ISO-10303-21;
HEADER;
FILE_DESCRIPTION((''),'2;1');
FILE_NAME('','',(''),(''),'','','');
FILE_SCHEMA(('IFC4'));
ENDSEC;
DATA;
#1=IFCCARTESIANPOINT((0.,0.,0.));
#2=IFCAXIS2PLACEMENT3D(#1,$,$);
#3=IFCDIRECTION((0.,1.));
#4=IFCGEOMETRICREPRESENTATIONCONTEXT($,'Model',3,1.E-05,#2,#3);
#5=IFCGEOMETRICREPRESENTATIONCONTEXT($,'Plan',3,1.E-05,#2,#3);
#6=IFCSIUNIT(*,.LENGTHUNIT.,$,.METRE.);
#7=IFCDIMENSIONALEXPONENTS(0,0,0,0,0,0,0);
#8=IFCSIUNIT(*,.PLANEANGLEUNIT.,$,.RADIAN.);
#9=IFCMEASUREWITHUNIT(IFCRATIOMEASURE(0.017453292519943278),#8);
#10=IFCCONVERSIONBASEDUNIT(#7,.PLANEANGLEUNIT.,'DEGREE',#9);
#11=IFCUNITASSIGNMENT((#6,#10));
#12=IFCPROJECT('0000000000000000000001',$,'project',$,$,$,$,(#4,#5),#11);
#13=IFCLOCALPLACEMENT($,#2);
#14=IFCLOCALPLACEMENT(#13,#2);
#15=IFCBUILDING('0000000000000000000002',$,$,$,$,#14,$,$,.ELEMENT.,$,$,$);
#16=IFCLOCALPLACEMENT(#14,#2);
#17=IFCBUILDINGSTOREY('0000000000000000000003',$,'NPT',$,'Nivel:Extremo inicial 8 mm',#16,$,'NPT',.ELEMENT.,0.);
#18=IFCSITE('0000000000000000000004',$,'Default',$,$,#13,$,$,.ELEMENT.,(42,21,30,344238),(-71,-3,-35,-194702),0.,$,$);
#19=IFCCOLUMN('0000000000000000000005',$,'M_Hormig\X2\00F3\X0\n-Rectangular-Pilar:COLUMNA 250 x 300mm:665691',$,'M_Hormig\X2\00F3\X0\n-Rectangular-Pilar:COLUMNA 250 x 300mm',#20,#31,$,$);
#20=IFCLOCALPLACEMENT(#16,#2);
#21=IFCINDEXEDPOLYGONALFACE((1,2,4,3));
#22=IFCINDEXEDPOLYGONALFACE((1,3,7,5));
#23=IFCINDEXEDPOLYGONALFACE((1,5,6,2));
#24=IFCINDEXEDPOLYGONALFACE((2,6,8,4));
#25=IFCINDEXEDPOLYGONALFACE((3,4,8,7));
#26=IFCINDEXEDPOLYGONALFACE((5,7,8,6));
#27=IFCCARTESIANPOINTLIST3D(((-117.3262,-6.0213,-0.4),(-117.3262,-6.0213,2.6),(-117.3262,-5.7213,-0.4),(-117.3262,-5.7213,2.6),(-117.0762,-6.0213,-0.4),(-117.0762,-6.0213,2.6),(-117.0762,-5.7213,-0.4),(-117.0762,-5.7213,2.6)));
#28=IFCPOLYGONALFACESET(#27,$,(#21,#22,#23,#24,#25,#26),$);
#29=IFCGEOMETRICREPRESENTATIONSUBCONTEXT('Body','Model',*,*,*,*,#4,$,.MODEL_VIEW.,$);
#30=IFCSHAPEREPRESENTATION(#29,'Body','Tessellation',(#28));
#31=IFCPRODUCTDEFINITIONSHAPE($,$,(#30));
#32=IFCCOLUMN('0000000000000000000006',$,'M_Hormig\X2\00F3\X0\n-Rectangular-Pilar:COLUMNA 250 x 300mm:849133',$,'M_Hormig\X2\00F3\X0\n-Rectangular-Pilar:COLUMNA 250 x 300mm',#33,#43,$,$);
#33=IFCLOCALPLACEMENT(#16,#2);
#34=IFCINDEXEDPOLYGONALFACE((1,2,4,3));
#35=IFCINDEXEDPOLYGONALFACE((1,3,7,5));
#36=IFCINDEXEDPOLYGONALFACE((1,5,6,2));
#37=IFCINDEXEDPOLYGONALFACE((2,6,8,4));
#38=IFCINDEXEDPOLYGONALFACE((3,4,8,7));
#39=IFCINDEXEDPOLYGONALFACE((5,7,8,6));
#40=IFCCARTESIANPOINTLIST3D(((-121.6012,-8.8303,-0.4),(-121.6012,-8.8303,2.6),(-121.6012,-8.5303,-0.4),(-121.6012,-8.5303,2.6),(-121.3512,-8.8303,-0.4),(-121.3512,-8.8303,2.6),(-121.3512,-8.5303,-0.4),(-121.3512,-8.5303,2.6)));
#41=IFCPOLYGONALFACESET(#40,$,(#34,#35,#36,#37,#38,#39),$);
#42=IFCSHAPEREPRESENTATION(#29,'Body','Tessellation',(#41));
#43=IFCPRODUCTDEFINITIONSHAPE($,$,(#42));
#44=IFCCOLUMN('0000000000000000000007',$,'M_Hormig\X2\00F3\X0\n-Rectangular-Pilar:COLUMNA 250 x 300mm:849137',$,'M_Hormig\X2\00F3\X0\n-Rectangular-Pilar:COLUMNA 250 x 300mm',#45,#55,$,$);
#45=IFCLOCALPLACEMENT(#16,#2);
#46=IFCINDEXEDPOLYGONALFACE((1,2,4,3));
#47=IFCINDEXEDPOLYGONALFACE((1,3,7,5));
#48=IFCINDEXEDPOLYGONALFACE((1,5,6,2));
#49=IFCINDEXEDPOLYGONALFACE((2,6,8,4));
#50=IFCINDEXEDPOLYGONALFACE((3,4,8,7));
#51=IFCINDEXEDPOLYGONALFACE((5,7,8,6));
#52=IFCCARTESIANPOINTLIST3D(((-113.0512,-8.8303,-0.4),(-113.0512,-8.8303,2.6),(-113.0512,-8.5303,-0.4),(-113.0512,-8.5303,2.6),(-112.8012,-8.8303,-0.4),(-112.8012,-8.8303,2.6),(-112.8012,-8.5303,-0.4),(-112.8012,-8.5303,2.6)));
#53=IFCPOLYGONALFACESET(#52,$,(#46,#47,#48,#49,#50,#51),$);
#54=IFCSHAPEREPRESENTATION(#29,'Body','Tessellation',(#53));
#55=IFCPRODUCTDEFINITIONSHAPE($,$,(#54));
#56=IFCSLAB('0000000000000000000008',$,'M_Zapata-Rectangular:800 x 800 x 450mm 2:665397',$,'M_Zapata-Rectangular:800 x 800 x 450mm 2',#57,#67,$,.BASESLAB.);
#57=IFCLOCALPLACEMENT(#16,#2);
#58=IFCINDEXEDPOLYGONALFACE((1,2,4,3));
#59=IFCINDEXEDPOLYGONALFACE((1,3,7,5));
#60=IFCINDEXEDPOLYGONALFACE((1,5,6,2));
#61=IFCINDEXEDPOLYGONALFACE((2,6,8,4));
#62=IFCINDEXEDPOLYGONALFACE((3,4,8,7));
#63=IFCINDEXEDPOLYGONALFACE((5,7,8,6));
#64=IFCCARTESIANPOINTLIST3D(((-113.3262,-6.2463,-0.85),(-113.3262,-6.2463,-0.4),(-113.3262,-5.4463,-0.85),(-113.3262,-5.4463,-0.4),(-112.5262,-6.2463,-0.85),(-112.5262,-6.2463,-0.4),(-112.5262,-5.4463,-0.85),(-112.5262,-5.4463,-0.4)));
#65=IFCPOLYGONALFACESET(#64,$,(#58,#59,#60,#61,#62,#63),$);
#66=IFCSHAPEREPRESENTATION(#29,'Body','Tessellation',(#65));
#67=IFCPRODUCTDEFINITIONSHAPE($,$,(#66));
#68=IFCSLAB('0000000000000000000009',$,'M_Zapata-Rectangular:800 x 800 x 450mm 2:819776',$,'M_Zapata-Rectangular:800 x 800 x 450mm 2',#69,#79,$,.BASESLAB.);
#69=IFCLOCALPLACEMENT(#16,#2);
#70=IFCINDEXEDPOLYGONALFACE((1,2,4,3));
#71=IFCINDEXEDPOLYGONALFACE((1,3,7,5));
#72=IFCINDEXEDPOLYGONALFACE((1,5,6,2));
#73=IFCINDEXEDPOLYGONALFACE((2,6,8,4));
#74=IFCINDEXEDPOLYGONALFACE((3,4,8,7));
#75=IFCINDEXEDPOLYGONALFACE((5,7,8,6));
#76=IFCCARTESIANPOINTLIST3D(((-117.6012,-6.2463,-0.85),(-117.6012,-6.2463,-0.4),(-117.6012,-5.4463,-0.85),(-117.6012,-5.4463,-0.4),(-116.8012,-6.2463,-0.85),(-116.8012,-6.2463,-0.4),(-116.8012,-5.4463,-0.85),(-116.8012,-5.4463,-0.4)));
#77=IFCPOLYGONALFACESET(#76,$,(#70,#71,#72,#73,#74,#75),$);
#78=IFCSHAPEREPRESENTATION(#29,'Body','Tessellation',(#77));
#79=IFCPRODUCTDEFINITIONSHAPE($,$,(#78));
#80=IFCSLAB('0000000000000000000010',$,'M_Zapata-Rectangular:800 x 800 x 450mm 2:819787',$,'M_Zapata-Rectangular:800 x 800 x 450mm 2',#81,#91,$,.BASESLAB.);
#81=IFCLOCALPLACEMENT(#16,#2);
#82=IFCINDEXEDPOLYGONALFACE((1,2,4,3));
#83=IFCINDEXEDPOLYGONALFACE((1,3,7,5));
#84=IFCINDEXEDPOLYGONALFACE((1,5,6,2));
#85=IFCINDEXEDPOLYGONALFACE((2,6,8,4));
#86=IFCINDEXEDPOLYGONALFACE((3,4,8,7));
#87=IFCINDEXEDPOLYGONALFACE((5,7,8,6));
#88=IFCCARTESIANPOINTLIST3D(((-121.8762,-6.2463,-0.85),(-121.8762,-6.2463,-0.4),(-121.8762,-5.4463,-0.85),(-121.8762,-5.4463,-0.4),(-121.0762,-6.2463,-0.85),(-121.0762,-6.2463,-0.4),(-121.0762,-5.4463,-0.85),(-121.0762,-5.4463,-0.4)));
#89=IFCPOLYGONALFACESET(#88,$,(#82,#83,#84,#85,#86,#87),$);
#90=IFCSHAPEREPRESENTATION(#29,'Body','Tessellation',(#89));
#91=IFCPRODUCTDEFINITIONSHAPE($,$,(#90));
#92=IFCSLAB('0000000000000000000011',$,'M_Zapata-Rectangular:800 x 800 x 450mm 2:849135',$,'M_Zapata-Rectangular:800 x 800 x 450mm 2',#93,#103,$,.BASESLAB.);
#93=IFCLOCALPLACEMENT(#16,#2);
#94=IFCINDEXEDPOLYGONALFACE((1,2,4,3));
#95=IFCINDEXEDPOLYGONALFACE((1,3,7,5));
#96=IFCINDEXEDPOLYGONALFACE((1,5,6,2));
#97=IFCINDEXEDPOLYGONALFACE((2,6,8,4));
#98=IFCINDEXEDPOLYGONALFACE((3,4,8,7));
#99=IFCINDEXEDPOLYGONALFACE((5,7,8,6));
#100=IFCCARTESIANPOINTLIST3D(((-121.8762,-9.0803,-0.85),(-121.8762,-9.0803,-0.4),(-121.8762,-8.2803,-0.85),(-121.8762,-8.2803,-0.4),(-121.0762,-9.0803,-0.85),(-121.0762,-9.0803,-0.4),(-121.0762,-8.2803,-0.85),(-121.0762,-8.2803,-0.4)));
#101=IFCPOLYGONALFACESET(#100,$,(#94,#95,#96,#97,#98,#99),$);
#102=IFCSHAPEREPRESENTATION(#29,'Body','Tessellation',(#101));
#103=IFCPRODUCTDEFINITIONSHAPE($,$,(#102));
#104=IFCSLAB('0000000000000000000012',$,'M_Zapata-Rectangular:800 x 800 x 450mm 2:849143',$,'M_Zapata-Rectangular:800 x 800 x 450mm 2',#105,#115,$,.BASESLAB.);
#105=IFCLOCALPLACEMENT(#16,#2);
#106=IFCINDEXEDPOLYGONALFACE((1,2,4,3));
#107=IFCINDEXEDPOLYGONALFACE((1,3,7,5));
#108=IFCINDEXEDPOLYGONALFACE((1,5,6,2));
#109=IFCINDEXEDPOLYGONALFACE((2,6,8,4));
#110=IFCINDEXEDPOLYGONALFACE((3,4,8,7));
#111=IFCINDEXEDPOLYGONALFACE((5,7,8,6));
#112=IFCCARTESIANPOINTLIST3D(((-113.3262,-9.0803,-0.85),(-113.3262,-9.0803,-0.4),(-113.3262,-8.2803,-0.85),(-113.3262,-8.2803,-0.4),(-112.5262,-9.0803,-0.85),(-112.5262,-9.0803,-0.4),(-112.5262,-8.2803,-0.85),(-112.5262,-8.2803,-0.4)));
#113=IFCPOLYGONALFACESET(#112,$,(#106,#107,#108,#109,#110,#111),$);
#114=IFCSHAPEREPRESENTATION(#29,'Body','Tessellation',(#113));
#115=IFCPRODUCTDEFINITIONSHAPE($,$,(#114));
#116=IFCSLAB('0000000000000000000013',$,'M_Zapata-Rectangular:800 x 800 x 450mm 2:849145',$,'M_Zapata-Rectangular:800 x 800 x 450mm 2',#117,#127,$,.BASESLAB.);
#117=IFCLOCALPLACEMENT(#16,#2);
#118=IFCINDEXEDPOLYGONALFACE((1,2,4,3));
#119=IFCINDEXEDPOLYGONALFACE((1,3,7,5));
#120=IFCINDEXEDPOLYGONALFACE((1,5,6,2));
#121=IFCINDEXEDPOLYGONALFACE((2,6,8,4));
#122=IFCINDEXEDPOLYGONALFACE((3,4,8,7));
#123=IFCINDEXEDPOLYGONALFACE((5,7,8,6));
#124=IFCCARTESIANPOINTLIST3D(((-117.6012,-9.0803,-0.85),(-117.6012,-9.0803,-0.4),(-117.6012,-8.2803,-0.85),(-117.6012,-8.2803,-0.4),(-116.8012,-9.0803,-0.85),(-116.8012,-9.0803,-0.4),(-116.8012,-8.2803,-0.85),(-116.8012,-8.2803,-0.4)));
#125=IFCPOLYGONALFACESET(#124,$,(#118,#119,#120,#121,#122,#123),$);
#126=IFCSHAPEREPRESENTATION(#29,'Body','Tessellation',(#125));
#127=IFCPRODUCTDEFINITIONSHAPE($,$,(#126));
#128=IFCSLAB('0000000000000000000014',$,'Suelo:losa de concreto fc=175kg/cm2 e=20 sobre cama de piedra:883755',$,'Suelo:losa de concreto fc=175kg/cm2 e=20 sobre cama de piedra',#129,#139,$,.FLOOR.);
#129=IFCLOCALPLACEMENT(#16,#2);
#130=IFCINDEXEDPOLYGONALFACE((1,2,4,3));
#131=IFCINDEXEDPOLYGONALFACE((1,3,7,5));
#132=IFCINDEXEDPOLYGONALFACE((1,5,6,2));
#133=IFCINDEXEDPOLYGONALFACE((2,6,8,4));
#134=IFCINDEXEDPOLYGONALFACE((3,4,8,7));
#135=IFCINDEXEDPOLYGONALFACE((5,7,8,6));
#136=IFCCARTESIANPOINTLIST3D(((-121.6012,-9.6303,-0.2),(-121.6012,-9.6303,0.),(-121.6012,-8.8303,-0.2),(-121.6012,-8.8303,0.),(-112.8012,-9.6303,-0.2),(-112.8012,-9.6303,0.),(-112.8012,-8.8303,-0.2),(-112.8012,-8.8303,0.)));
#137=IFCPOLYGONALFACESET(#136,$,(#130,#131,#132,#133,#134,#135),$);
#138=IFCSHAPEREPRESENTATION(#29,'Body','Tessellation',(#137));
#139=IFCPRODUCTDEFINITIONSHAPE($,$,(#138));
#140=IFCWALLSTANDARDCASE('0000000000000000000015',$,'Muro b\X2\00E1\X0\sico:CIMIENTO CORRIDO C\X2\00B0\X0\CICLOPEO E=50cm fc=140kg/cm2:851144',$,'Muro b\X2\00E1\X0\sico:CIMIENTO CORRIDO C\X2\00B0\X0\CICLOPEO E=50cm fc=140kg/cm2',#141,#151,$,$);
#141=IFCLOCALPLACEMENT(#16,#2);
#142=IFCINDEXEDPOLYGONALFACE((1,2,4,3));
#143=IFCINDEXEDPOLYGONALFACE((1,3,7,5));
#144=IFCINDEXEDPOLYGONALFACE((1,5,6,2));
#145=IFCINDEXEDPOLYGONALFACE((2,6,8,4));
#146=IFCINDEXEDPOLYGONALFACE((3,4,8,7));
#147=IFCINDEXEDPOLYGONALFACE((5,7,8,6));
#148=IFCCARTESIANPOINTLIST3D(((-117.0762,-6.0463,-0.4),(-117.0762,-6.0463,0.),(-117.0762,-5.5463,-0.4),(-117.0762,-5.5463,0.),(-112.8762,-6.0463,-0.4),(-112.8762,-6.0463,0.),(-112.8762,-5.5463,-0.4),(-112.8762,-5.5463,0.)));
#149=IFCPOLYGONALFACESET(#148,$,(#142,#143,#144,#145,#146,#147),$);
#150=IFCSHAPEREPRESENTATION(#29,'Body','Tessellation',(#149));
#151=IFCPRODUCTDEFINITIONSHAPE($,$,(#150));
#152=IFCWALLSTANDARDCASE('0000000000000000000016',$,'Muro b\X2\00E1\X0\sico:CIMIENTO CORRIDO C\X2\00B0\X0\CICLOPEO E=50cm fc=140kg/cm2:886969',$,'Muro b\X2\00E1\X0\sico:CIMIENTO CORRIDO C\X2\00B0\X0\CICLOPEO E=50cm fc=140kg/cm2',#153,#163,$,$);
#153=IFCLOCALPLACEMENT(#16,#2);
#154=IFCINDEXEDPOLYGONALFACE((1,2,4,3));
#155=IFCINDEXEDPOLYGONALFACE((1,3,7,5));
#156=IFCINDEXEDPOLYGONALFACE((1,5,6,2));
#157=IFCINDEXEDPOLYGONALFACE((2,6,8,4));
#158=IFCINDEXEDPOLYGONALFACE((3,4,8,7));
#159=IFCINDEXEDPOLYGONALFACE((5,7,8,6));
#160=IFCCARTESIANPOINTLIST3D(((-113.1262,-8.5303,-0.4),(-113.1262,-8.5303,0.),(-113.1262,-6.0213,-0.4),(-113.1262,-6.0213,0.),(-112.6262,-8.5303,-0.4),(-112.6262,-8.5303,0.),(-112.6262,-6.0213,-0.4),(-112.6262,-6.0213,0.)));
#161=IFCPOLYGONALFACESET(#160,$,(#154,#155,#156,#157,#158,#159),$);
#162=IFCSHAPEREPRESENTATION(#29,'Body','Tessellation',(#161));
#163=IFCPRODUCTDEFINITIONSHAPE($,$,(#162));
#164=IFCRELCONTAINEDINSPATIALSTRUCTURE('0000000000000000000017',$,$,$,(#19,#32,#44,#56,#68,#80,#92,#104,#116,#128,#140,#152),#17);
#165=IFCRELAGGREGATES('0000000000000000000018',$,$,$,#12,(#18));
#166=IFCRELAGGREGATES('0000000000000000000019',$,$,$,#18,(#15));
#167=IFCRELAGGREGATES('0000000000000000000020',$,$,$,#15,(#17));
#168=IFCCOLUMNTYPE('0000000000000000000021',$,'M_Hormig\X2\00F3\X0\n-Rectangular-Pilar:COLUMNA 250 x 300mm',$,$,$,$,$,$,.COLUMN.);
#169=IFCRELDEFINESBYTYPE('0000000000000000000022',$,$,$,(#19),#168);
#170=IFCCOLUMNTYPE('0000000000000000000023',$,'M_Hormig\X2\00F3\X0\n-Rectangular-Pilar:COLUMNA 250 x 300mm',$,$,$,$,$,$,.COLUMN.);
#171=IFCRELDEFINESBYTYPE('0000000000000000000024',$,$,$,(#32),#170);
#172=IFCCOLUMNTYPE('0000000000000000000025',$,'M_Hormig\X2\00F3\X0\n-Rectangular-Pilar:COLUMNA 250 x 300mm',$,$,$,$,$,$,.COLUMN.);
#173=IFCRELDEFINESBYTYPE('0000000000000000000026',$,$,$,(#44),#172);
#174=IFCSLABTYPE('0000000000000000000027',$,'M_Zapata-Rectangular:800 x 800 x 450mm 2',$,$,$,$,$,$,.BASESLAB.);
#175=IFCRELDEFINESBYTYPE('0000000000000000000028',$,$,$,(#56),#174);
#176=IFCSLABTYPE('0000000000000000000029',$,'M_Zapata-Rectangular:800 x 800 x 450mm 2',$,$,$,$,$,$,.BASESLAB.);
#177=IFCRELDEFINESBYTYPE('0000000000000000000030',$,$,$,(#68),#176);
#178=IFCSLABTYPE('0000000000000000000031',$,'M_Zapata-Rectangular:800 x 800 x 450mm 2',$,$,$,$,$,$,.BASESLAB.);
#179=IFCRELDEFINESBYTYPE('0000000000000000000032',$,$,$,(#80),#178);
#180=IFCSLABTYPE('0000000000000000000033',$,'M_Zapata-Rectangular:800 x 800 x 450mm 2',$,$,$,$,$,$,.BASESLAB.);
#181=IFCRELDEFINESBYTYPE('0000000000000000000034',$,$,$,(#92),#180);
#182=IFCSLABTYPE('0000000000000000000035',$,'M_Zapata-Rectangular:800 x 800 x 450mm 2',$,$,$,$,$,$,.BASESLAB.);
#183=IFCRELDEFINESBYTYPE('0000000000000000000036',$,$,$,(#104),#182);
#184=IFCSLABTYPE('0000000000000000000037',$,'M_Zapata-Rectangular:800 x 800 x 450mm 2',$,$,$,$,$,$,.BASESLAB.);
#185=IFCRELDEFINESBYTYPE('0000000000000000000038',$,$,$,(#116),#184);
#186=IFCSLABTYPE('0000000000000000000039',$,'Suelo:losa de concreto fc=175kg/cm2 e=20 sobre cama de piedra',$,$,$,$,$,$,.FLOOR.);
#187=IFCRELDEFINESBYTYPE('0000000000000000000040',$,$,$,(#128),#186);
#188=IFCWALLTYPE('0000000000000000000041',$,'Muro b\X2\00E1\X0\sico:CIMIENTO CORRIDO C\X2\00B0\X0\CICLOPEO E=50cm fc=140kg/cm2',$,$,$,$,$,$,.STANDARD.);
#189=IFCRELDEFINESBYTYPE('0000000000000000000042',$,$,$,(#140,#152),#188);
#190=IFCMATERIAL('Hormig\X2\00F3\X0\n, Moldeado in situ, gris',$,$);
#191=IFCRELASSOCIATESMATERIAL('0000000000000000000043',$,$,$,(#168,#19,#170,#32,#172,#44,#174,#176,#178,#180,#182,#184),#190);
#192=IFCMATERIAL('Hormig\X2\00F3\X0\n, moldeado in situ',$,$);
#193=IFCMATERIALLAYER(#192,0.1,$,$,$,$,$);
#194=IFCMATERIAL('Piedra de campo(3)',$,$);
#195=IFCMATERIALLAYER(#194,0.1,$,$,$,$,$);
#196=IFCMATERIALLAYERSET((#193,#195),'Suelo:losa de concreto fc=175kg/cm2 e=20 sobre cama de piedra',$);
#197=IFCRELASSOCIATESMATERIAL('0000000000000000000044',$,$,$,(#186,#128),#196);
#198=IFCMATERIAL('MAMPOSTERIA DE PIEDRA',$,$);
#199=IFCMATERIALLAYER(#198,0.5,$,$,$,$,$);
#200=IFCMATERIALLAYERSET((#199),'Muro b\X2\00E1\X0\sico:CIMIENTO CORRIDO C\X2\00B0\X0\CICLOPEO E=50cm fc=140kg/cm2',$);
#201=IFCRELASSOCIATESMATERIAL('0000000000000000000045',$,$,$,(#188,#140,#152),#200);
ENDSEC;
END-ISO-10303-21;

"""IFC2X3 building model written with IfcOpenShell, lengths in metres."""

from ifc_helpers import new_model, entity, si_unit, converted_unit, direction, frame, frame_2d, origin, origin_2d_with_axis, place, context, subcontext, project, spatial, rectangle, extrude, source, transform, mapped, material, layer, layer_set, layer_usage, type_object, type_shapes, element, save


model = new_model("IFC2X3")

# Units and contexts
model_context = context("Model", 3, precision=1e-05, world=origin(), true_north=direction((0.0, 1.0)))
plan_context = context("Plan", 3, precision=1e-05, world=origin(), true_north=direction((0.0, 1.0)))
body_context = subcontext(model_context, "Body", "Model", "MODEL_VIEW")
ifc_project = project(units=[si_unit("LENGTHUNIT", "METRE"), converted_unit("PLANEANGLEUNIT", "DEGREE", entity("IfcRatioMeasure", 0.017453292519943278), si_unit("PLANEANGLEUNIT", "RADIAN"), dimensions=[0, 0, 0, 0, 0, 0, 0])], contexts=[model_context, plan_context])

# Site, building, storey
site_placement = place(None, origin())
site = spatial("IfcSite", under=ifc_project, at=site_placement, Name="Default", CompositionType="ELEMENT", RefLatitude=(42, 21, 30, 344238), RefLongitude=(-71, -3, -35, -194702), RefElevation=0.0)
building_placement = place(site_placement, origin())
building = spatial("IfcBuilding", under=site, at=building_placement, CompositionType="ELEMENT")
storey_placement = place(building_placement, origin())
storey = spatial("IfcBuildingStorey", under=building, at=storey_placement, Name="NPT", ObjectType="Nivel:Extremo inicial 8 mm", LongName="NPT", CompositionType="ELEMENT", Elevation=0.0)

# Columns
ifc_material_1 = material(Name="Hormigón, Moldeado in situ, gris")
column_type_1 = type_object("IfcColumnType", Name="M_Hormigón-Rectangular-Pilar:COLUMNA 250 x 300mm", PredefinedType="COLUMN", material=ifc_material_1)
shared_shape_1 = source(origin(), body_context, "Body", "SweptSolid", [
    extrude(rectangle(XDim=0.3, YDim=0.25, at=origin_2d_with_axis()), frame((-117.2012, -5.8713, -0.4), z_axis=(0.0, 0.0, 1.0), x_axis=(0.0, -1.0, 0.0)), (0.0, 0.0, 1.0), 3.0),
])
type_shapes(column_type_1, [shared_shape_1])
column_1_placement = place(storey_placement, origin())
element("IfcColumn", 1, at=column_1_placement, inside=storey, type_object=column_type_1, material=ifc_material_1, Name="M_Hormigón-Rectangular-Pilar:COLUMNA 250 x 300mm:665691", ObjectType="M_Hormigón-Rectangular-Pilar:COLUMNA 250 x 300mm", context=body_context, shape_type="MappedRepresentation", body=[
    mapped(shared_shape_1, transform((0.0, 0.0, 0.0), scale=1.0)),
])
column_type_2 = type_object("IfcColumnType", Name="M_Hormigón-Rectangular-Pilar:COLUMNA 250 x 300mm", PredefinedType="COLUMN", material=ifc_material_1)
shared_shape_2 = source(origin(), body_context, "Body", "SweptSolid", [
    extrude(rectangle(XDim=0.3, YDim=0.25, at=frame_2d((0.0, 0.0), x_axis=(1.0, 0.0))), frame((-121.4762, -8.6803, -0.4), z_axis=(0.0, 0.0, 1.0), x_axis=(0.0, -1.0, 0.0)), (0.0, 0.0, 1.0), 3.0),
])
type_shapes(column_type_2, [shared_shape_2])
column_2_placement = place(storey_placement, origin())
element("IfcColumn", 2, at=column_2_placement, inside=storey, type_object=column_type_2, material=ifc_material_1, Name="M_Hormigón-Rectangular-Pilar:COLUMNA 250 x 300mm:849133", ObjectType="M_Hormigón-Rectangular-Pilar:COLUMNA 250 x 300mm", context=body_context, shape_type="MappedRepresentation", body=[
    mapped(shared_shape_2, transform((0.0, 0.0, 0.0), scale=1.0)),
])
column_type_3 = type_object("IfcColumnType", Name="M_Hormigón-Rectangular-Pilar:COLUMNA 250 x 300mm", PredefinedType="COLUMN", material=ifc_material_1)
shared_shape_3 = source(origin(), body_context, "Body", "SweptSolid", [
    extrude(rectangle(XDim=0.3, YDim=0.25, at=frame_2d((0.0, 0.0), x_axis=(1.0, 0.0))), frame((-112.9262, -8.6803, -0.4), z_axis=(0.0, 0.0, 1.0), x_axis=(0.0, -1.0, 0.0)), (0.0, 0.0, 1.0), 3.0),
])
type_shapes(column_type_3, [shared_shape_3])
column_3_placement = place(storey_placement, origin())
element("IfcColumn", 3, at=column_3_placement, inside=storey, type_object=column_type_3, material=ifc_material_1, Name="M_Hormigón-Rectangular-Pilar:COLUMNA 250 x 300mm:849137", ObjectType="M_Hormigón-Rectangular-Pilar:COLUMNA 250 x 300mm", context=body_context, shape_type="MappedRepresentation", body=[
    mapped(shared_shape_3, transform((0.0, 0.0, 0.0), scale=1.0)),
])

# Slabs
slab_type_1 = type_object("IfcSlabType", Name="M_Zapata-Rectangular:800 x 800 x 450mm 2", PredefinedType="BASESLAB", material=ifc_material_1)
slab_1_placement = place(storey_placement, origin())
element("IfcSlab", 4, at=slab_1_placement, inside=storey, type_object=slab_type_1, Name="M_Zapata-Rectangular:800 x 800 x 450mm 2:665397", ObjectType="M_Zapata-Rectangular:800 x 800 x 450mm 2", PredefinedType="BASESLAB", context=body_context, shape_type="SweptSolid", body=[
    extrude(rectangle(XDim=0.8, YDim=0.8, at=frame_2d((0.0, 0.0), x_axis=(1.0, 0.0))), frame((-112.9262, -5.8463, -0.85), z_axis=(0.0, 0.0, 1.0), x_axis=(0.0, 1.0, 0.0)), (0.0, 0.0, 1.0), 0.45),
])
slab_type_2 = type_object("IfcSlabType", Name="M_Zapata-Rectangular:800 x 800 x 450mm 2", PredefinedType="BASESLAB", material=ifc_material_1)
slab_2_placement = place(storey_placement, origin())
element("IfcSlab", 5, at=slab_2_placement, inside=storey, type_object=slab_type_2, Name="M_Zapata-Rectangular:800 x 800 x 450mm 2:819776", ObjectType="M_Zapata-Rectangular:800 x 800 x 450mm 2", PredefinedType="BASESLAB", context=body_context, shape_type="SweptSolid", body=[
    extrude(rectangle(XDim=0.8, YDim=0.8, at=frame_2d((0.0, 0.0), x_axis=(1.0, 0.0))), frame((-117.2012, -5.8463, -0.85), z_axis=(0.0, 0.0, 1.0), x_axis=(0.0, 1.0, 0.0)), (0.0, 0.0, 1.0), 0.45),
])
slab_type_3 = type_object("IfcSlabType", Name="M_Zapata-Rectangular:800 x 800 x 450mm 2", PredefinedType="BASESLAB", material=ifc_material_1)
slab_3_placement = place(storey_placement, origin())
element("IfcSlab", 6, at=slab_3_placement, inside=storey, type_object=slab_type_3, Name="M_Zapata-Rectangular:800 x 800 x 450mm 2:819787", ObjectType="M_Zapata-Rectangular:800 x 800 x 450mm 2", PredefinedType="BASESLAB", context=body_context, shape_type="SweptSolid", body=[
    extrude(rectangle(XDim=0.8, YDim=0.8, at=frame_2d((0.0, 0.0), x_axis=(1.0, 0.0))), frame((-121.4762, -5.8463, -0.85), z_axis=(0.0, 0.0, 1.0), x_axis=(0.0, 1.0, 0.0)), (0.0, 0.0, 1.0), 0.45),
])

# Slabs
slab_type_4 = type_object("IfcSlabType", Name="M_Zapata-Rectangular:800 x 800 x 450mm 2", PredefinedType="BASESLAB", material=ifc_material_1)
slab_4_placement = place(storey_placement, origin())
element("IfcSlab", 7, at=slab_4_placement, inside=storey, type_object=slab_type_4, Name="M_Zapata-Rectangular:800 x 800 x 450mm 2:849135", ObjectType="M_Zapata-Rectangular:800 x 800 x 450mm 2", PredefinedType="BASESLAB", context=body_context, shape_type="SweptSolid", body=[
    extrude(rectangle(XDim=0.8, YDim=0.8, at=frame_2d((0.0, 0.0), x_axis=(1.0, 0.0))), frame((-121.4762, -8.6803, -0.85), z_axis=(0.0, 0.0, 1.0), x_axis=(0.0, 1.0, 0.0)), (0.0, 0.0, 1.0), 0.45),
])
slab_type_5 = type_object("IfcSlabType", Name="M_Zapata-Rectangular:800 x 800 x 450mm 2", PredefinedType="BASESLAB", material=ifc_material_1)
slab_5_placement = place(storey_placement, origin())
element("IfcSlab", 8, at=slab_5_placement, inside=storey, type_object=slab_type_5, Name="M_Zapata-Rectangular:800 x 800 x 450mm 2:849143", ObjectType="M_Zapata-Rectangular:800 x 800 x 450mm 2", PredefinedType="BASESLAB", context=body_context, shape_type="SweptSolid", body=[
    extrude(rectangle(XDim=0.8, YDim=0.8, at=frame_2d((0.0, 0.0), x_axis=(1.0, 0.0))), frame((-112.9262, -8.6803, -0.85), z_axis=(0.0, 0.0, 1.0), x_axis=(0.0, 1.0, 0.0)), (0.0, 0.0, 1.0), 0.45),
])
slab_type_6 = type_object("IfcSlabType", Name="M_Zapata-Rectangular:800 x 800 x 450mm 2", PredefinedType="BASESLAB", material=ifc_material_1)
slab_6_placement = place(storey_placement, origin())
element("IfcSlab", 9, at=slab_6_placement, inside=storey, type_object=slab_type_6, Name="M_Zapata-Rectangular:800 x 800 x 450mm 2:849145", ObjectType="M_Zapata-Rectangular:800 x 800 x 450mm 2", PredefinedType="BASESLAB", context=body_context, shape_type="SweptSolid", body=[
    extrude(rectangle(XDim=0.8, YDim=0.8, at=frame_2d((0.0, 0.0), x_axis=(1.0, 0.0))), frame((-117.2012, -8.6803, -0.85), z_axis=(0.0, 0.0, 1.0), x_axis=(0.0, 1.0, 0.0)), (0.0, 0.0, 1.0), 0.45),
])

# Slab
ifc_material_2 = material(Name="Hormigón, moldeado in situ")
ifc_layer_1 = layer(ifc_material_2, 0.1)
ifc_material_3 = material(Name="Piedra de campo(3)")
ifc_layer_2 = layer(ifc_material_3, 0.1)
ifc_layer_set_1 = layer_set([ifc_layer_1, ifc_layer_2], Name="Suelo:losa de concreto fc=175kg/cm2 e=20 sobre cama de piedra")
ifc_layer_usage_1 = layer_usage(ifc_layer_set_1, "AXIS3", "POSITIVE", 0.0)
slab_type_7 = type_object("IfcSlabType", Name="Suelo:losa de concreto fc=175kg/cm2 e=20 sobre cama de piedra", PredefinedType="FLOOR", material=ifc_layer_set_1)
slab_7_placement = place(storey_placement, origin())
element("IfcSlab", 10, at=slab_7_placement, inside=storey, type_object=slab_type_7, material=ifc_layer_usage_1, Name="Suelo:losa de concreto fc=175kg/cm2 e=20 sobre cama de piedra:883755", ObjectType="Suelo:losa de concreto fc=175kg/cm2 e=20 sobre cama de piedra", PredefinedType="FLOOR", context=body_context, shape_type="SweptSolid", body=[
    extrude(rectangle(XDim=0.8, YDim=8.8, at=origin_2d_with_axis()), frame((-117.2012, -9.2303, 0.0), z_axis=(0.0, 0.0, -1.0), x_axis=(0.0, 1.0, 0.0)), (0.0, 0.0, 1.0), 0.2),
])

# Walls
ifc_material_4 = material(Name="MAMPOSTERIA DE PIEDRA")
ifc_layer_3 = layer(ifc_material_4, 0.5)
ifc_layer_set_2 = layer_set([ifc_layer_3], Name="Muro básico:CIMIENTO CORRIDO C°CICLOPEO E=50cm fc=140kg/cm2")
ifc_layer_usage_2 = layer_usage(ifc_layer_set_2, "AXIS2", "POSITIVE", -0.25)
wall_type_1 = type_object("IfcWallType", Name="Muro básico:CIMIENTO CORRIDO C°CICLOPEO E=50cm fc=140kg/cm2", PredefinedType="STANDARD", material=ifc_layer_set_2)
wall_1_placement = place(storey_placement, frame((-112.8762, -5.7963, -0.4), z_axis=(0.0, 0.0, 1.0), x_axis=(-1.0, 0.0, 0.0)))
element("IfcWallStandardCase", 11, at=wall_1_placement, inside=storey, type_object=wall_type_1, material=ifc_layer_usage_2, Name="Muro básico:CIMIENTO CORRIDO C°CICLOPEO E=50cm fc=140kg/cm2:851144", ObjectType="Muro básico:CIMIENTO CORRIDO C°CICLOPEO E=50cm fc=140kg/cm2", context=body_context, shape_type="SweptSolid", body=[
    extrude(rectangle(XDim=4.2, YDim=0.5, at=frame_2d((2.1, 0.0), x_axis=(-1.0, 0.0))), origin(), (0.0, 0.0, 1.0), 0.4),
])
ifc_layer_usage_3 = layer_usage(ifc_layer_set_2, "AXIS2", "POSITIVE", -0.25)
wall_2_placement = place(storey_placement, frame((-112.8762, -6.0213, -0.4), z_axis=(0.0, 0.0, 1.0), x_axis=(0.0, -1.0, 0.0)))
element("IfcWallStandardCase", 12, at=wall_2_placement, inside=storey, type_object=wall_type_1, material=ifc_layer_usage_3, Name="Muro básico:CIMIENTO CORRIDO C°CICLOPEO E=50cm fc=140kg/cm2:886969", ObjectType="Muro básico:CIMIENTO CORRIDO C°CICLOPEO E=50cm fc=140kg/cm2", context=body_context, shape_type="SweptSolid", body=[
    extrude(rectangle(XDim=2.5091, YDim=0.5, at=frame_2d((1.2545, 0.0), x_axis=(-1.0, 0.0))), origin(), (0.0, 0.0, 1.0), 0.4),
])

save(model, "model.ifc")
